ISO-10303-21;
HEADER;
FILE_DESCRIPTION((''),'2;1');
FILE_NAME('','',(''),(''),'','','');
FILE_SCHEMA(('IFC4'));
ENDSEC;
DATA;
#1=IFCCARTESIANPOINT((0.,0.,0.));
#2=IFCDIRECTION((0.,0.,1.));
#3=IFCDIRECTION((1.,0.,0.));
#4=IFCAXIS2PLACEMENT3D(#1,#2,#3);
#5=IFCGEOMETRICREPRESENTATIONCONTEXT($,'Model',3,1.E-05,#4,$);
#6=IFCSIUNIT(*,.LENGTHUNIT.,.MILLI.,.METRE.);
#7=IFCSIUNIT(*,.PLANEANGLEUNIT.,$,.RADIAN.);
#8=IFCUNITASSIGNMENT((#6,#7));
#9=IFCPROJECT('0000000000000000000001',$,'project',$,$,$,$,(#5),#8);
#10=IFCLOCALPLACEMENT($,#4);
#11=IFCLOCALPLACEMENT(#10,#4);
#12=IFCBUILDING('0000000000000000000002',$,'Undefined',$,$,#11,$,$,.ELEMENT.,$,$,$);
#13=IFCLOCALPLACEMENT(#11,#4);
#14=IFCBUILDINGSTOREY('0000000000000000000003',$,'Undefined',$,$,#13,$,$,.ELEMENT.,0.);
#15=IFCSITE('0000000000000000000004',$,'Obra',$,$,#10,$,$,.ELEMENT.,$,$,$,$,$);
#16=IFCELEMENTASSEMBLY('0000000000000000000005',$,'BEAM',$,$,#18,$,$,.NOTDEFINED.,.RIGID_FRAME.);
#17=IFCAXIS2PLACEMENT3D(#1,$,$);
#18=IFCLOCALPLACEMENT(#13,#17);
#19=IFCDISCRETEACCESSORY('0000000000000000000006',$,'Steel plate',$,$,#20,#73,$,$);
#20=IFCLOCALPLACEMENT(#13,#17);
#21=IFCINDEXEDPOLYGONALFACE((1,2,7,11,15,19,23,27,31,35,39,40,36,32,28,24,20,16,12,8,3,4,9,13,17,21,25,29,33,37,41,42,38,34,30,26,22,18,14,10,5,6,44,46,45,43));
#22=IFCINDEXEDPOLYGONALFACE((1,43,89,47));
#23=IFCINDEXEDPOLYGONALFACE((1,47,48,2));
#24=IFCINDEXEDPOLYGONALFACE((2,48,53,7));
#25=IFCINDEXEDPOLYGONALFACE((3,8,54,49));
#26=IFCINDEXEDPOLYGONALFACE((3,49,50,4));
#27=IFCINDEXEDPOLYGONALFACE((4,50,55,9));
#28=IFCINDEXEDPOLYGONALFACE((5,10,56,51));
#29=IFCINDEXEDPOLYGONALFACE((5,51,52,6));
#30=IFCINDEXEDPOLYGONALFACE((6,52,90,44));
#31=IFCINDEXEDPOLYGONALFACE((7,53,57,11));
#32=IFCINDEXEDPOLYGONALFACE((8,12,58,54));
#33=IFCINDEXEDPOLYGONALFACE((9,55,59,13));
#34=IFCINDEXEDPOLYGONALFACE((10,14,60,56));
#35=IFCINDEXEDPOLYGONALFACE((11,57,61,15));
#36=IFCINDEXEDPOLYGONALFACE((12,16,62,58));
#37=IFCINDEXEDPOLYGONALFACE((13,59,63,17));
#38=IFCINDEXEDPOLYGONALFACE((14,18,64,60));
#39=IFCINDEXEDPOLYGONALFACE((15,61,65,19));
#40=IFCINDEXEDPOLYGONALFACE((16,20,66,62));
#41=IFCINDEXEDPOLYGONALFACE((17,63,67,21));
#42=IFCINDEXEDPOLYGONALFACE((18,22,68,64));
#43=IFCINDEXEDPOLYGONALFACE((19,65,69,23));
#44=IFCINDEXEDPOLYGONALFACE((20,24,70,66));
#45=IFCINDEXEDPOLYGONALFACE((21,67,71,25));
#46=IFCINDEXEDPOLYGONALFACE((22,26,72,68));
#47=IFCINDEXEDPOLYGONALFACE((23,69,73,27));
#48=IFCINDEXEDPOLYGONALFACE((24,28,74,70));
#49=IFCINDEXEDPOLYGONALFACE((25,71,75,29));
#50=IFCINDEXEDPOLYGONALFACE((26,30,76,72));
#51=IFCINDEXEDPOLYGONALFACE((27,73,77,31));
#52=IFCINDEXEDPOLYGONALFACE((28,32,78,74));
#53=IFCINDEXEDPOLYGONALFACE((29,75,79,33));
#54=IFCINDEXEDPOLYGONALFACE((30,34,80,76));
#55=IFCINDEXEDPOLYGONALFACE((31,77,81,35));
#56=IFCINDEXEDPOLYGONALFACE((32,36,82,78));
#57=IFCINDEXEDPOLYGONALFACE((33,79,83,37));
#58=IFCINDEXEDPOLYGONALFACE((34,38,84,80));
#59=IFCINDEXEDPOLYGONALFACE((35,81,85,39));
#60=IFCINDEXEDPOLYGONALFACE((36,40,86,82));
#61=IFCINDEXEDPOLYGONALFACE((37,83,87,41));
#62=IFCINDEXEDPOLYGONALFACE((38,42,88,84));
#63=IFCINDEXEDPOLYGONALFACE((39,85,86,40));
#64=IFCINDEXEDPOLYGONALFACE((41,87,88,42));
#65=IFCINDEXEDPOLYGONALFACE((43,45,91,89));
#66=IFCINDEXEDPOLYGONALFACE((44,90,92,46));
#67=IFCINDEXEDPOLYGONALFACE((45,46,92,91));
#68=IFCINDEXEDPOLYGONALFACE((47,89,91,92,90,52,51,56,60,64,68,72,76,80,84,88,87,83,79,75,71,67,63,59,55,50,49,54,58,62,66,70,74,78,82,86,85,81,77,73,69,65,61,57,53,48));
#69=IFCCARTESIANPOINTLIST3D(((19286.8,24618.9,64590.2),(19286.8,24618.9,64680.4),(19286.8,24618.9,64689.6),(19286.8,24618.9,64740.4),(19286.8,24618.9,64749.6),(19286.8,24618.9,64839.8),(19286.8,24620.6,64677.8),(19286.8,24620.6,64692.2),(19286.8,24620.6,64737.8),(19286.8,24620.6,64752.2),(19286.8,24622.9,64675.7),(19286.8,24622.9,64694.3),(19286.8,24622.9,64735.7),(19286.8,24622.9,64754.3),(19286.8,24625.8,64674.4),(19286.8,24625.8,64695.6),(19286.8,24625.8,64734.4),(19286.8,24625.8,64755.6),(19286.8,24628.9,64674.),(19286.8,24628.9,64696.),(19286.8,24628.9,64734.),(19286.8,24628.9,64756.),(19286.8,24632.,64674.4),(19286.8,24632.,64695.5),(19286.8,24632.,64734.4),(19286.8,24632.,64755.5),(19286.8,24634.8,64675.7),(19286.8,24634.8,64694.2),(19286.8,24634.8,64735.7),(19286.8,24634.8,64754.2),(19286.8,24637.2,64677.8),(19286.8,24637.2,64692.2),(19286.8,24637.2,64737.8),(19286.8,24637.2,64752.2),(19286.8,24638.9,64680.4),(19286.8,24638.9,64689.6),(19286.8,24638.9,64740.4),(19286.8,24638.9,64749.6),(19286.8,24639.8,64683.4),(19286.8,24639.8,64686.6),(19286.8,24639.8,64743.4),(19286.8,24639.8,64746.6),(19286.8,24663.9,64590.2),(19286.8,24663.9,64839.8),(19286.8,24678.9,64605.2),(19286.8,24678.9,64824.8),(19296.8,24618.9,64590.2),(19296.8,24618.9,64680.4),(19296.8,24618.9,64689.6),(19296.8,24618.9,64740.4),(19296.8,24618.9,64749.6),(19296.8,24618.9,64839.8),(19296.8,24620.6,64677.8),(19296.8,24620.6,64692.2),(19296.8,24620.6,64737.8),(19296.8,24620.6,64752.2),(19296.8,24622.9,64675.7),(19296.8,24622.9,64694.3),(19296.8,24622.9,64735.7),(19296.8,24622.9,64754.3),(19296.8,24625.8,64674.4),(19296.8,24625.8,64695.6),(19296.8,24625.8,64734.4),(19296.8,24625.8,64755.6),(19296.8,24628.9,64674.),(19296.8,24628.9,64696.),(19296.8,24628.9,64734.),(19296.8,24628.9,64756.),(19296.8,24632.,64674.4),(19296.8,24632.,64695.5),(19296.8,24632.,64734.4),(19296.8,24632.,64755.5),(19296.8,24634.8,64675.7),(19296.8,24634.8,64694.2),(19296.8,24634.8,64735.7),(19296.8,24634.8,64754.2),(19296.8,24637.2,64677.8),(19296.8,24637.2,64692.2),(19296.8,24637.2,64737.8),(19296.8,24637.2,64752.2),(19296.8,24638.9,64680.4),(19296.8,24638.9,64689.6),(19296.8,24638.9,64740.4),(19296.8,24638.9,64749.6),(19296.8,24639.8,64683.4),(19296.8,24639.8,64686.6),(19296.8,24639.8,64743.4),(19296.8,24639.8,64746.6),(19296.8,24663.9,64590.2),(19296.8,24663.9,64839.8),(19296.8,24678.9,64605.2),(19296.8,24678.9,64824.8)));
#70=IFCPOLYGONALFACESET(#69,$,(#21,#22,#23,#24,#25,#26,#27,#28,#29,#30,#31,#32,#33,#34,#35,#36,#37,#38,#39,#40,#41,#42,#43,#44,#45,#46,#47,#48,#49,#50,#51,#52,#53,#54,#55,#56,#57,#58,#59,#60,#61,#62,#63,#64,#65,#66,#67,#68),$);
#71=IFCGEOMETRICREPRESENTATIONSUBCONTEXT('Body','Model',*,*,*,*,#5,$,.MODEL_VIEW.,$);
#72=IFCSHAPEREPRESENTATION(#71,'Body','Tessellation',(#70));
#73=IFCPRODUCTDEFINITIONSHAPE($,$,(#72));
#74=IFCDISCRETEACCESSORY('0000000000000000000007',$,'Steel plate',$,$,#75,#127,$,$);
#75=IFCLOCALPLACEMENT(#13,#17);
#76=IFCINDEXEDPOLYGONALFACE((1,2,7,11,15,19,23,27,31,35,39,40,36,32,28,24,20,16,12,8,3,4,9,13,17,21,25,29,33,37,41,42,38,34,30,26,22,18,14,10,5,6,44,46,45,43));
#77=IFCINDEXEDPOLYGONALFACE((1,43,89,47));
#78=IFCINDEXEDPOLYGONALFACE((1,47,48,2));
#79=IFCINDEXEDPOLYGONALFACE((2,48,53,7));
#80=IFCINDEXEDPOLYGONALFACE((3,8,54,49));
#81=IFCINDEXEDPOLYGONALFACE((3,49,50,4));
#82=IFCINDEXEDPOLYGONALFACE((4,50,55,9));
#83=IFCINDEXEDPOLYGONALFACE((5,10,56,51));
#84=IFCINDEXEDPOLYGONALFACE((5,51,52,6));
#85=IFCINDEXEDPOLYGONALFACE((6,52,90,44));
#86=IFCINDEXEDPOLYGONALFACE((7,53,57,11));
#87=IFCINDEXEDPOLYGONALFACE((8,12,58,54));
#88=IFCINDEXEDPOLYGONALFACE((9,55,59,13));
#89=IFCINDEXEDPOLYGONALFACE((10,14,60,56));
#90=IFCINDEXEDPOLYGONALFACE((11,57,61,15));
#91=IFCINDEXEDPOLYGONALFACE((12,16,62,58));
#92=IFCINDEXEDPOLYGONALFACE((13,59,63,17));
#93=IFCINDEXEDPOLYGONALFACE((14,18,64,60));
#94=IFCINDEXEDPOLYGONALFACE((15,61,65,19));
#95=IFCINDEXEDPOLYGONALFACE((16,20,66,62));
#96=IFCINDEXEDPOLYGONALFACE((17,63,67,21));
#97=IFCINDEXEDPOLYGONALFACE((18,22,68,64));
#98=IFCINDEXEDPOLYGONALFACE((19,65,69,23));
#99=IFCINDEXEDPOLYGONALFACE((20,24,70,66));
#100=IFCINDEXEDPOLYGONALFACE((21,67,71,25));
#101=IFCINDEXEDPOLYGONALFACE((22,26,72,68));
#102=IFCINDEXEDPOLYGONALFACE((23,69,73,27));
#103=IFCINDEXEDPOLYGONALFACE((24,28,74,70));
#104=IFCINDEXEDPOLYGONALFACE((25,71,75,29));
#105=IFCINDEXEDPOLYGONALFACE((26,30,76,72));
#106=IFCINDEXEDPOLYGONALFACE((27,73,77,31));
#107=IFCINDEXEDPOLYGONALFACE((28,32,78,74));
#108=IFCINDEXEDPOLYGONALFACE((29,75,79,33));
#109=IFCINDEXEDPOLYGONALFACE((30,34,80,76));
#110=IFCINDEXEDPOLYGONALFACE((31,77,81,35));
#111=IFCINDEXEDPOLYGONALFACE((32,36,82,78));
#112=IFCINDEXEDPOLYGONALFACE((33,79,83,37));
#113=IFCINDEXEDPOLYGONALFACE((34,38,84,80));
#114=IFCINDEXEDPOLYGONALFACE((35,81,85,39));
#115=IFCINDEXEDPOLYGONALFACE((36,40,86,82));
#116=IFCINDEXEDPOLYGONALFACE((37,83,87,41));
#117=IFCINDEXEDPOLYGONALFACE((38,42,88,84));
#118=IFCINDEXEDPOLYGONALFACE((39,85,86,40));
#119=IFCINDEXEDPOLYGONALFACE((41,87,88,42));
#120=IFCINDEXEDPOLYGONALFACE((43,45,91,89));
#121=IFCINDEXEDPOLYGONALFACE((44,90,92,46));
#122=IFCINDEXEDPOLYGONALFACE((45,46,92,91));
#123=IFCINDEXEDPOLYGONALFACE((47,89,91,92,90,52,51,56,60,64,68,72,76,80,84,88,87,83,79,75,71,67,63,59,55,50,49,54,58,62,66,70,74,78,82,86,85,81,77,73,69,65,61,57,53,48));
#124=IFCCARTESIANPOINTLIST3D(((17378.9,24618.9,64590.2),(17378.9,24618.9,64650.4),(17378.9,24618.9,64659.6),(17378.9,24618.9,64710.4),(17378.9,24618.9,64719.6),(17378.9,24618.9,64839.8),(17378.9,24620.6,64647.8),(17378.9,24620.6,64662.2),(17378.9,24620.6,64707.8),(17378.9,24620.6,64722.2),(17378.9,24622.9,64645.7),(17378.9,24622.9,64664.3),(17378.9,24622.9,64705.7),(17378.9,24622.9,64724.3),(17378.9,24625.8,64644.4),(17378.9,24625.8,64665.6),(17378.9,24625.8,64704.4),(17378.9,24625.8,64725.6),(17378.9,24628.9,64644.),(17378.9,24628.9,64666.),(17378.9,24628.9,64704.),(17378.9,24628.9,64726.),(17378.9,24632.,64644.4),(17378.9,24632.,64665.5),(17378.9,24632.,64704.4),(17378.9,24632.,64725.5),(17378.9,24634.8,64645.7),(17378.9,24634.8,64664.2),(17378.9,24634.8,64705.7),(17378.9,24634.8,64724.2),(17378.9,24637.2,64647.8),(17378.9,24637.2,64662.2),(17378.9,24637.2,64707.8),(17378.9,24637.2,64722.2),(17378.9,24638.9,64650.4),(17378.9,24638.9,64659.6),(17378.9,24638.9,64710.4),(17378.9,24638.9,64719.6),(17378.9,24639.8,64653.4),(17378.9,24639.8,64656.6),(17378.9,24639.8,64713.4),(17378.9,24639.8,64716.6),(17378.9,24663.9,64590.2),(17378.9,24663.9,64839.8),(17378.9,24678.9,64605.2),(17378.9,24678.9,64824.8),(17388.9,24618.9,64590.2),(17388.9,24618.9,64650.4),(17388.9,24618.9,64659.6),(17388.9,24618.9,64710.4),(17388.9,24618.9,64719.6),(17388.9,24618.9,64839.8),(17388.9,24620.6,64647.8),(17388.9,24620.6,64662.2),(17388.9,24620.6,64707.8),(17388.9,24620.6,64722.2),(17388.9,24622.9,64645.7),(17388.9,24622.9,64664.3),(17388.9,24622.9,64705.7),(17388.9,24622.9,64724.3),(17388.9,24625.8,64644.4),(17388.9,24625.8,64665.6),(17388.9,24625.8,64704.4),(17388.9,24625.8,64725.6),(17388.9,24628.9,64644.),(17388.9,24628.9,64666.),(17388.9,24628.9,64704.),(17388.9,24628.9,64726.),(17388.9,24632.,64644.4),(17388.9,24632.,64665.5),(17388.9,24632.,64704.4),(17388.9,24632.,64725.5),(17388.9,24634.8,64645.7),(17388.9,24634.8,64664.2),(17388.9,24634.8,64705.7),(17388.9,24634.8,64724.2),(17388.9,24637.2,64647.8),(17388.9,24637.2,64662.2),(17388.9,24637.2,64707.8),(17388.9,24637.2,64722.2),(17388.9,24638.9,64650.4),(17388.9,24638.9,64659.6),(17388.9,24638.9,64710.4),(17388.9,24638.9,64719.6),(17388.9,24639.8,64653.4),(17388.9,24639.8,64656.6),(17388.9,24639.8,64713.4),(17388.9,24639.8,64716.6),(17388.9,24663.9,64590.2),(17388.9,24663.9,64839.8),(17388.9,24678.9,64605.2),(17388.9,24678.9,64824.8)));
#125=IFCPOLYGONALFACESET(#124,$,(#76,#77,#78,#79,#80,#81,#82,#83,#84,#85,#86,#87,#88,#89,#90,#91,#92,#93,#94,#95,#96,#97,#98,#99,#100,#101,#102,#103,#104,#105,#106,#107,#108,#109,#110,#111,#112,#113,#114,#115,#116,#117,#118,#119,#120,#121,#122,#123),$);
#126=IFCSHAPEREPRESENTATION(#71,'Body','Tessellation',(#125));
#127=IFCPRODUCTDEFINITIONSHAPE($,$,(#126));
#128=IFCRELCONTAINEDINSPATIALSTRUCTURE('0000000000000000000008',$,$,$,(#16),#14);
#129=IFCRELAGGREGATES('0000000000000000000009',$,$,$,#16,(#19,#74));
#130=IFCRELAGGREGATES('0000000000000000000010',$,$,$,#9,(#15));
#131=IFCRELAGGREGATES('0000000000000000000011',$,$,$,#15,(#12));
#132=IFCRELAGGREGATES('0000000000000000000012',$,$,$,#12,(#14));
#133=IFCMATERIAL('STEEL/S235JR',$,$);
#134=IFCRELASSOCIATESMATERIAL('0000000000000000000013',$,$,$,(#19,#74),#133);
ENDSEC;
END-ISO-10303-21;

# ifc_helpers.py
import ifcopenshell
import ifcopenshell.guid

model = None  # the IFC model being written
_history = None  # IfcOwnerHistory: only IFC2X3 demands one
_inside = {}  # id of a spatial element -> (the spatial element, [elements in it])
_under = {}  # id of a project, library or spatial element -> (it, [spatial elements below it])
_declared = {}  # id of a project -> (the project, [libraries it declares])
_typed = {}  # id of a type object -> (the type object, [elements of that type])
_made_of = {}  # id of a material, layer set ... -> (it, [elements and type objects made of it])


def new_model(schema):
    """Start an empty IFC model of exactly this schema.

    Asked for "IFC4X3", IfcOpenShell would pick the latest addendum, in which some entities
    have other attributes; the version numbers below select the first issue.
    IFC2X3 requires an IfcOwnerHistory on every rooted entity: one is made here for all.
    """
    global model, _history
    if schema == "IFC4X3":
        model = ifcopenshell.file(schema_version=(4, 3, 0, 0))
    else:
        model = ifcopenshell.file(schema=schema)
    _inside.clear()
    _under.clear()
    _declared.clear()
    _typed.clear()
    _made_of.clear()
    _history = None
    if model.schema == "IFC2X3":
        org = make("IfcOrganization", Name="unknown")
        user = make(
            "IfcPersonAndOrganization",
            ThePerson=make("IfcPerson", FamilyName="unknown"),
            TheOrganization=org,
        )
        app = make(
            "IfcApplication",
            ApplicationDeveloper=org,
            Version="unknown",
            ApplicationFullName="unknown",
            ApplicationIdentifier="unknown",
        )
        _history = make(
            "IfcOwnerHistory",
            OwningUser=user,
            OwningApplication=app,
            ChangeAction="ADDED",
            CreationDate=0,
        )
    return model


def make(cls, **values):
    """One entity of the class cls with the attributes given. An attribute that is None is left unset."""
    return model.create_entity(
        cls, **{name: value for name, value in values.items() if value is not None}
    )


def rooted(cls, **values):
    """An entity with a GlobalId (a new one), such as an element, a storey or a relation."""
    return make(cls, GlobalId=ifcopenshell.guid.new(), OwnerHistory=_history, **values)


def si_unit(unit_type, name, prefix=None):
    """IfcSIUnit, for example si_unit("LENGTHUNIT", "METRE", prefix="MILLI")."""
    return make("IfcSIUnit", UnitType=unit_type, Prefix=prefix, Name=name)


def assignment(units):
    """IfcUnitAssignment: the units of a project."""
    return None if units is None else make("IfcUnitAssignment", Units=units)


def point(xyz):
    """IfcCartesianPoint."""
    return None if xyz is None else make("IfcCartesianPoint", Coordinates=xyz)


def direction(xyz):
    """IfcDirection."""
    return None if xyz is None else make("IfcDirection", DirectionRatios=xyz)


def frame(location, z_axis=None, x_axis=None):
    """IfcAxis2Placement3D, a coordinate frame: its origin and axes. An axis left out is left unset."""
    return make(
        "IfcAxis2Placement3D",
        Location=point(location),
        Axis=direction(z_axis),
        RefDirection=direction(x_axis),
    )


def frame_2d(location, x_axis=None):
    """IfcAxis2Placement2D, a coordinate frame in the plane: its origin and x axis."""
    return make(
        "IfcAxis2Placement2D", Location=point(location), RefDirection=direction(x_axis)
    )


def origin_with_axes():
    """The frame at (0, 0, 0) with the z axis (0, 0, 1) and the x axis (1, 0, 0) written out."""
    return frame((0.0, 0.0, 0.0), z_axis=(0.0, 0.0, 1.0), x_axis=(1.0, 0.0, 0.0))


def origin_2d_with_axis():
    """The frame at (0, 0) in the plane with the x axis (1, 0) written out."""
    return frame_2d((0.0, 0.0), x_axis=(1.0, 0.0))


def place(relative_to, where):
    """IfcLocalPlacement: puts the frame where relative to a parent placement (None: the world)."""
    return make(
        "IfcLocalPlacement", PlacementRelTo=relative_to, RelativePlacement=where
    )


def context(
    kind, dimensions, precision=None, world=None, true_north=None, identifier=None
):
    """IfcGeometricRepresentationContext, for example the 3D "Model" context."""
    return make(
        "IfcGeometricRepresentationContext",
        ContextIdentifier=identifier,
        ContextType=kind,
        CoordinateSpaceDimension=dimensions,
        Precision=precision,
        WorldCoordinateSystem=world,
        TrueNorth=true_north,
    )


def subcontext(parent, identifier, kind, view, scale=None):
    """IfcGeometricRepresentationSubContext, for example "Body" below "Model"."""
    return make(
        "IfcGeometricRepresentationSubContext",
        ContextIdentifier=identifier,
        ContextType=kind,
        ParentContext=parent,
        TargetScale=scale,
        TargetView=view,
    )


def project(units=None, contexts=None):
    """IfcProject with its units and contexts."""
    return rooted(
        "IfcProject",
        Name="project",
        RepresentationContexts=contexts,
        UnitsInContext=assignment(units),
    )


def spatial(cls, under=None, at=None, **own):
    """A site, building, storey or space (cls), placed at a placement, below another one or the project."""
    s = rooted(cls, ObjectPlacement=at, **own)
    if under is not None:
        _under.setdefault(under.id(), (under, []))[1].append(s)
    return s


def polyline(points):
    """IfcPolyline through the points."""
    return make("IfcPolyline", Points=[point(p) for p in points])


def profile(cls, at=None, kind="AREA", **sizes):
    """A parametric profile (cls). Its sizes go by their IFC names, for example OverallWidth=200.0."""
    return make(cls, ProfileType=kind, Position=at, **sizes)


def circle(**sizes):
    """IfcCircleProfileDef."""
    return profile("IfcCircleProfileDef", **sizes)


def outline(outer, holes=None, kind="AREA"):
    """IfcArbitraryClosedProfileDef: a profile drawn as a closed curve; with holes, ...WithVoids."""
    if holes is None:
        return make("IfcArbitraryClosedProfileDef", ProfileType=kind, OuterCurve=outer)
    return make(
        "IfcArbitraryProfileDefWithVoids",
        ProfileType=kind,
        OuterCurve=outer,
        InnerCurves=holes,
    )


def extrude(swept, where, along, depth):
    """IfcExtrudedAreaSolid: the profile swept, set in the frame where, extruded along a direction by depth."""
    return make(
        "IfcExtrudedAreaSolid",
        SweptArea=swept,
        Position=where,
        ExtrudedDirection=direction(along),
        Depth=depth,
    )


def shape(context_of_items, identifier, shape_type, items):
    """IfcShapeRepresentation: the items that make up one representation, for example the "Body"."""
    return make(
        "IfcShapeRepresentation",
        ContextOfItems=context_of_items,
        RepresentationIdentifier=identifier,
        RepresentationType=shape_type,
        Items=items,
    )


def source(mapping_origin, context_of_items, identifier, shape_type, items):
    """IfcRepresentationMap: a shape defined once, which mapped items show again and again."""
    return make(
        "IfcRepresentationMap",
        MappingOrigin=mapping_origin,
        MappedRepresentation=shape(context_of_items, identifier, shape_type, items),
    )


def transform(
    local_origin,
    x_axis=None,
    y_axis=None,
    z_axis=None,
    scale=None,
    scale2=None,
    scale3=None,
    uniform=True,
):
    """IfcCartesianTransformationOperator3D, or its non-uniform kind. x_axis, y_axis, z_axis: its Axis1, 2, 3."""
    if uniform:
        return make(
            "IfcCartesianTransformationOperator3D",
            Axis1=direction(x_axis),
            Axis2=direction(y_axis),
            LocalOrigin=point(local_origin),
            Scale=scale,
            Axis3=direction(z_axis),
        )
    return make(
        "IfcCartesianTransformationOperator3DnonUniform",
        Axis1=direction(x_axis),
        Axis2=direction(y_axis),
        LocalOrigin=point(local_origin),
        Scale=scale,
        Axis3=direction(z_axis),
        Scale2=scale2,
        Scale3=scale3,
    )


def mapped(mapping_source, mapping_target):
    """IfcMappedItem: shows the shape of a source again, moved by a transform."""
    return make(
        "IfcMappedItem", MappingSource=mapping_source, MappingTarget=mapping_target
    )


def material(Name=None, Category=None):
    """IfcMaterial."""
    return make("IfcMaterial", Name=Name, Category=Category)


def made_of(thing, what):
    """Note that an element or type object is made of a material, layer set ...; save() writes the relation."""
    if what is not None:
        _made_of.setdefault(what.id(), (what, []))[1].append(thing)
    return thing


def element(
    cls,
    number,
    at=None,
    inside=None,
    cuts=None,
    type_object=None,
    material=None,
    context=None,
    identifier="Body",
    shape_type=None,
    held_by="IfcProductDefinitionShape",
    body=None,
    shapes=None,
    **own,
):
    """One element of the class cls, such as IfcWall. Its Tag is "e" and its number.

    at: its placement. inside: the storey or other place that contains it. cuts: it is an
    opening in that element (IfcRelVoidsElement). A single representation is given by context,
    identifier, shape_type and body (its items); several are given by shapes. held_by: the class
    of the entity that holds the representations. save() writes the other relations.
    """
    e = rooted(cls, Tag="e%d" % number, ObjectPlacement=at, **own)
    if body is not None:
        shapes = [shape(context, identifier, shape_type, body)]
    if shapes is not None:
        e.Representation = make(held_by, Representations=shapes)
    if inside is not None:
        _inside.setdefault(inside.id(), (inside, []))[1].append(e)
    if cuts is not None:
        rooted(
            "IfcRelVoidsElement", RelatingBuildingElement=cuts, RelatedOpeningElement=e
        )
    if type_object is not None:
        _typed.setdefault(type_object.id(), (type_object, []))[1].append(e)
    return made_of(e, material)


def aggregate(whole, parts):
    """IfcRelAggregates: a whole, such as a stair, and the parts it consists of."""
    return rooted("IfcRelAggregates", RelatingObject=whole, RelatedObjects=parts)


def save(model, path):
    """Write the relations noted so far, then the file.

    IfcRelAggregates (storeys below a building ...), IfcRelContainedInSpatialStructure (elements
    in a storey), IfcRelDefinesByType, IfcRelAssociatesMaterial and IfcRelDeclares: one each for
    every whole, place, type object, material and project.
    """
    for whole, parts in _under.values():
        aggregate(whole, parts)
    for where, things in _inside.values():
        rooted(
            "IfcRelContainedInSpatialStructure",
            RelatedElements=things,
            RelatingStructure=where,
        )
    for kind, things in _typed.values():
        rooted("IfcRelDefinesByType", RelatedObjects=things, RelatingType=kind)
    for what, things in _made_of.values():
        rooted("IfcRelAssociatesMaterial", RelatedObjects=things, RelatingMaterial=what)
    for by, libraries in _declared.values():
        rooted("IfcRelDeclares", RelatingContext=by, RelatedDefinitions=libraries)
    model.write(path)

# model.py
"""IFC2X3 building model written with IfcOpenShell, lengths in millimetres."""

from ifc_helpers import new_model, si_unit, frame, origin_with_axes, origin_2d_with_axis, place, context, subcontext, project, spatial, polyline, circle, outline, extrude, source, transform, mapped, material, element, aggregate, save


model = new_model("IFC2X3")

# Units and contexts
model_context = context("Model", 3, precision=1e-05, world=origin_with_axes())
body_context = subcontext(model_context, "Body", "Model", "MODEL_VIEW")
ifc_project = project(units=[si_unit("LENGTHUNIT", "METRE", prefix="MILLI"), si_unit("PLANEANGLEUNIT", "RADIAN")], contexts=[model_context])

# Site, building, storey
site_placement = place(None, origin_with_axes())
site = spatial("IfcSite", under=ifc_project, at=site_placement, Name="Obra", CompositionType="ELEMENT")
building_placement = place(site_placement, origin_with_axes())
building = spatial("IfcBuilding", under=site, at=building_placement, Name="Undefined", CompositionType="ELEMENT")
storey_placement = place(building_placement, origin_with_axes())
storey = spatial("IfcBuildingStorey", under=building, at=storey_placement, Name="Undefined", CompositionType="ELEMENT", Elevation=0.0)

# Shared definitions
ifc_material_1 = material(Name="STEEL/S235JR")

# Element assembly
assembly_1_placement = place(storey_placement, origin_with_axes())
assembly_1 = element("IfcElementAssembly", 1, at=assembly_1_placement, inside=storey, Name="BEAM", AssemblyPlace="NOTDEFINED", PredefinedType="RIGID_FRAME")

# Discrete accessories, openings
discrete_accessory_1_placement = place(assembly_1_placement, frame((19291.8, 24618.9, 64590.2), z_axis=(1.0, 0.000002, 0.0), x_axis=(-0.000002, 1.0, 0.0)))
discrete_accessory_1 = element("IfcDiscreteAccessory", 2, at=discrete_accessory_1_placement, material=ifc_material_1, Name="Steel plate", context=body_context, shape_type="SweptSolid", body=[
    extrude(outline(polyline([(0.0, 0.0), (45.0, 0.0), (60.0, 15.0), (60.0, 234.6), (45.0, 249.6), (0.0, 249.6), (0.0, 0.0)])), frame((0.0, 0.0, -5.0), z_axis=(0.0, 0.0, 1.0), x_axis=(1.0, 0.0, 0.0)), (0.0, 0.0, 1.0), 10.0),
])
shared_shape_1 = source(origin_with_axes(), body_context, "Body", "SweptSolid", [
    extrude(circle(Radius=11.0, at=origin_2d_with_axis()), frame((0.0, -13.4, 0.0), z_axis=(0.0, 1.0, 0.0), x_axis=(1.0, 0.0, 0.0)), (0.0, 0.0, 1.0), 10.2),
])
opening_1_placement = place(assembly_1_placement, frame((19300.1, 24668.9, 64850.0), z_axis=(0.000002, -1.0, 0.0), x_axis=(0.0, 0.0, -1.0)))
element("IfcOpeningElement", 3, at=opening_1_placement, cuts=discrete_accessory_1, ObjectType="Opening", context=body_context, shape_type="MappedRepresentation", body=[
    mapped(shared_shape_1, transform((105.0, 0.0, 40.0))),
    mapped(shared_shape_1, transform((165.0, 0.0, 40.0))),
])
discrete_accessory_2_placement = place(assembly_1_placement, frame((17383.9, 24618.9, 64590.2), z_axis=(1.0, 0.000002, 0.0), x_axis=(-0.000002, 1.0, 0.0)))
discrete_accessory_2 = element("IfcDiscreteAccessory", 4, at=discrete_accessory_2_placement, material=ifc_material_1, Name="Steel plate", context=body_context, shape_type="SweptSolid", body=[
    extrude(outline(polyline([(0.0, 0.0), (45.0, 0.0), (60.0, 15.0), (60.0, 234.6), (45.0, 249.6), (0.0, 249.6), (0.0, 0.0)])), frame((0.0, 0.0, -5.0), z_axis=(0.0, 0.0, 1.0), x_axis=(1.0, 0.0, 0.0)), (0.0, 0.0, 1.0), 10.0),
])
shared_shape_2 = source(origin_with_axes(), body_context, "Body", "SweptSolid", [
    extrude(circle(Radius=11.0, at=origin_2d_with_axis()), frame((0.0, -13.9, 0.0), z_axis=(0.0, 1.0, 0.0), x_axis=(1.0, 0.0, 0.0)), (0.0, 0.0, 1.0), 10.2),
])
opening_2_placement = place(assembly_1_placement, frame((17392.7, 24668.9, 64850.0), z_axis=(0.000002, -1.0, 0.0), x_axis=(0.0, 0.0, -1.0)))
element("IfcOpeningElement", 5, at=opening_2_placement, cuts=discrete_accessory_2, ObjectType="Opening", context=body_context, shape_type="MappedRepresentation", body=[
    mapped(shared_shape_2, transform((135.0, 0.0, 40.0))),
    mapped(shared_shape_2, transform((195.0, 0.0, 40.0))),
])
aggregate(assembly_1, [discrete_accessory_1, discrete_accessory_2])

save(model, "model.ifc")
